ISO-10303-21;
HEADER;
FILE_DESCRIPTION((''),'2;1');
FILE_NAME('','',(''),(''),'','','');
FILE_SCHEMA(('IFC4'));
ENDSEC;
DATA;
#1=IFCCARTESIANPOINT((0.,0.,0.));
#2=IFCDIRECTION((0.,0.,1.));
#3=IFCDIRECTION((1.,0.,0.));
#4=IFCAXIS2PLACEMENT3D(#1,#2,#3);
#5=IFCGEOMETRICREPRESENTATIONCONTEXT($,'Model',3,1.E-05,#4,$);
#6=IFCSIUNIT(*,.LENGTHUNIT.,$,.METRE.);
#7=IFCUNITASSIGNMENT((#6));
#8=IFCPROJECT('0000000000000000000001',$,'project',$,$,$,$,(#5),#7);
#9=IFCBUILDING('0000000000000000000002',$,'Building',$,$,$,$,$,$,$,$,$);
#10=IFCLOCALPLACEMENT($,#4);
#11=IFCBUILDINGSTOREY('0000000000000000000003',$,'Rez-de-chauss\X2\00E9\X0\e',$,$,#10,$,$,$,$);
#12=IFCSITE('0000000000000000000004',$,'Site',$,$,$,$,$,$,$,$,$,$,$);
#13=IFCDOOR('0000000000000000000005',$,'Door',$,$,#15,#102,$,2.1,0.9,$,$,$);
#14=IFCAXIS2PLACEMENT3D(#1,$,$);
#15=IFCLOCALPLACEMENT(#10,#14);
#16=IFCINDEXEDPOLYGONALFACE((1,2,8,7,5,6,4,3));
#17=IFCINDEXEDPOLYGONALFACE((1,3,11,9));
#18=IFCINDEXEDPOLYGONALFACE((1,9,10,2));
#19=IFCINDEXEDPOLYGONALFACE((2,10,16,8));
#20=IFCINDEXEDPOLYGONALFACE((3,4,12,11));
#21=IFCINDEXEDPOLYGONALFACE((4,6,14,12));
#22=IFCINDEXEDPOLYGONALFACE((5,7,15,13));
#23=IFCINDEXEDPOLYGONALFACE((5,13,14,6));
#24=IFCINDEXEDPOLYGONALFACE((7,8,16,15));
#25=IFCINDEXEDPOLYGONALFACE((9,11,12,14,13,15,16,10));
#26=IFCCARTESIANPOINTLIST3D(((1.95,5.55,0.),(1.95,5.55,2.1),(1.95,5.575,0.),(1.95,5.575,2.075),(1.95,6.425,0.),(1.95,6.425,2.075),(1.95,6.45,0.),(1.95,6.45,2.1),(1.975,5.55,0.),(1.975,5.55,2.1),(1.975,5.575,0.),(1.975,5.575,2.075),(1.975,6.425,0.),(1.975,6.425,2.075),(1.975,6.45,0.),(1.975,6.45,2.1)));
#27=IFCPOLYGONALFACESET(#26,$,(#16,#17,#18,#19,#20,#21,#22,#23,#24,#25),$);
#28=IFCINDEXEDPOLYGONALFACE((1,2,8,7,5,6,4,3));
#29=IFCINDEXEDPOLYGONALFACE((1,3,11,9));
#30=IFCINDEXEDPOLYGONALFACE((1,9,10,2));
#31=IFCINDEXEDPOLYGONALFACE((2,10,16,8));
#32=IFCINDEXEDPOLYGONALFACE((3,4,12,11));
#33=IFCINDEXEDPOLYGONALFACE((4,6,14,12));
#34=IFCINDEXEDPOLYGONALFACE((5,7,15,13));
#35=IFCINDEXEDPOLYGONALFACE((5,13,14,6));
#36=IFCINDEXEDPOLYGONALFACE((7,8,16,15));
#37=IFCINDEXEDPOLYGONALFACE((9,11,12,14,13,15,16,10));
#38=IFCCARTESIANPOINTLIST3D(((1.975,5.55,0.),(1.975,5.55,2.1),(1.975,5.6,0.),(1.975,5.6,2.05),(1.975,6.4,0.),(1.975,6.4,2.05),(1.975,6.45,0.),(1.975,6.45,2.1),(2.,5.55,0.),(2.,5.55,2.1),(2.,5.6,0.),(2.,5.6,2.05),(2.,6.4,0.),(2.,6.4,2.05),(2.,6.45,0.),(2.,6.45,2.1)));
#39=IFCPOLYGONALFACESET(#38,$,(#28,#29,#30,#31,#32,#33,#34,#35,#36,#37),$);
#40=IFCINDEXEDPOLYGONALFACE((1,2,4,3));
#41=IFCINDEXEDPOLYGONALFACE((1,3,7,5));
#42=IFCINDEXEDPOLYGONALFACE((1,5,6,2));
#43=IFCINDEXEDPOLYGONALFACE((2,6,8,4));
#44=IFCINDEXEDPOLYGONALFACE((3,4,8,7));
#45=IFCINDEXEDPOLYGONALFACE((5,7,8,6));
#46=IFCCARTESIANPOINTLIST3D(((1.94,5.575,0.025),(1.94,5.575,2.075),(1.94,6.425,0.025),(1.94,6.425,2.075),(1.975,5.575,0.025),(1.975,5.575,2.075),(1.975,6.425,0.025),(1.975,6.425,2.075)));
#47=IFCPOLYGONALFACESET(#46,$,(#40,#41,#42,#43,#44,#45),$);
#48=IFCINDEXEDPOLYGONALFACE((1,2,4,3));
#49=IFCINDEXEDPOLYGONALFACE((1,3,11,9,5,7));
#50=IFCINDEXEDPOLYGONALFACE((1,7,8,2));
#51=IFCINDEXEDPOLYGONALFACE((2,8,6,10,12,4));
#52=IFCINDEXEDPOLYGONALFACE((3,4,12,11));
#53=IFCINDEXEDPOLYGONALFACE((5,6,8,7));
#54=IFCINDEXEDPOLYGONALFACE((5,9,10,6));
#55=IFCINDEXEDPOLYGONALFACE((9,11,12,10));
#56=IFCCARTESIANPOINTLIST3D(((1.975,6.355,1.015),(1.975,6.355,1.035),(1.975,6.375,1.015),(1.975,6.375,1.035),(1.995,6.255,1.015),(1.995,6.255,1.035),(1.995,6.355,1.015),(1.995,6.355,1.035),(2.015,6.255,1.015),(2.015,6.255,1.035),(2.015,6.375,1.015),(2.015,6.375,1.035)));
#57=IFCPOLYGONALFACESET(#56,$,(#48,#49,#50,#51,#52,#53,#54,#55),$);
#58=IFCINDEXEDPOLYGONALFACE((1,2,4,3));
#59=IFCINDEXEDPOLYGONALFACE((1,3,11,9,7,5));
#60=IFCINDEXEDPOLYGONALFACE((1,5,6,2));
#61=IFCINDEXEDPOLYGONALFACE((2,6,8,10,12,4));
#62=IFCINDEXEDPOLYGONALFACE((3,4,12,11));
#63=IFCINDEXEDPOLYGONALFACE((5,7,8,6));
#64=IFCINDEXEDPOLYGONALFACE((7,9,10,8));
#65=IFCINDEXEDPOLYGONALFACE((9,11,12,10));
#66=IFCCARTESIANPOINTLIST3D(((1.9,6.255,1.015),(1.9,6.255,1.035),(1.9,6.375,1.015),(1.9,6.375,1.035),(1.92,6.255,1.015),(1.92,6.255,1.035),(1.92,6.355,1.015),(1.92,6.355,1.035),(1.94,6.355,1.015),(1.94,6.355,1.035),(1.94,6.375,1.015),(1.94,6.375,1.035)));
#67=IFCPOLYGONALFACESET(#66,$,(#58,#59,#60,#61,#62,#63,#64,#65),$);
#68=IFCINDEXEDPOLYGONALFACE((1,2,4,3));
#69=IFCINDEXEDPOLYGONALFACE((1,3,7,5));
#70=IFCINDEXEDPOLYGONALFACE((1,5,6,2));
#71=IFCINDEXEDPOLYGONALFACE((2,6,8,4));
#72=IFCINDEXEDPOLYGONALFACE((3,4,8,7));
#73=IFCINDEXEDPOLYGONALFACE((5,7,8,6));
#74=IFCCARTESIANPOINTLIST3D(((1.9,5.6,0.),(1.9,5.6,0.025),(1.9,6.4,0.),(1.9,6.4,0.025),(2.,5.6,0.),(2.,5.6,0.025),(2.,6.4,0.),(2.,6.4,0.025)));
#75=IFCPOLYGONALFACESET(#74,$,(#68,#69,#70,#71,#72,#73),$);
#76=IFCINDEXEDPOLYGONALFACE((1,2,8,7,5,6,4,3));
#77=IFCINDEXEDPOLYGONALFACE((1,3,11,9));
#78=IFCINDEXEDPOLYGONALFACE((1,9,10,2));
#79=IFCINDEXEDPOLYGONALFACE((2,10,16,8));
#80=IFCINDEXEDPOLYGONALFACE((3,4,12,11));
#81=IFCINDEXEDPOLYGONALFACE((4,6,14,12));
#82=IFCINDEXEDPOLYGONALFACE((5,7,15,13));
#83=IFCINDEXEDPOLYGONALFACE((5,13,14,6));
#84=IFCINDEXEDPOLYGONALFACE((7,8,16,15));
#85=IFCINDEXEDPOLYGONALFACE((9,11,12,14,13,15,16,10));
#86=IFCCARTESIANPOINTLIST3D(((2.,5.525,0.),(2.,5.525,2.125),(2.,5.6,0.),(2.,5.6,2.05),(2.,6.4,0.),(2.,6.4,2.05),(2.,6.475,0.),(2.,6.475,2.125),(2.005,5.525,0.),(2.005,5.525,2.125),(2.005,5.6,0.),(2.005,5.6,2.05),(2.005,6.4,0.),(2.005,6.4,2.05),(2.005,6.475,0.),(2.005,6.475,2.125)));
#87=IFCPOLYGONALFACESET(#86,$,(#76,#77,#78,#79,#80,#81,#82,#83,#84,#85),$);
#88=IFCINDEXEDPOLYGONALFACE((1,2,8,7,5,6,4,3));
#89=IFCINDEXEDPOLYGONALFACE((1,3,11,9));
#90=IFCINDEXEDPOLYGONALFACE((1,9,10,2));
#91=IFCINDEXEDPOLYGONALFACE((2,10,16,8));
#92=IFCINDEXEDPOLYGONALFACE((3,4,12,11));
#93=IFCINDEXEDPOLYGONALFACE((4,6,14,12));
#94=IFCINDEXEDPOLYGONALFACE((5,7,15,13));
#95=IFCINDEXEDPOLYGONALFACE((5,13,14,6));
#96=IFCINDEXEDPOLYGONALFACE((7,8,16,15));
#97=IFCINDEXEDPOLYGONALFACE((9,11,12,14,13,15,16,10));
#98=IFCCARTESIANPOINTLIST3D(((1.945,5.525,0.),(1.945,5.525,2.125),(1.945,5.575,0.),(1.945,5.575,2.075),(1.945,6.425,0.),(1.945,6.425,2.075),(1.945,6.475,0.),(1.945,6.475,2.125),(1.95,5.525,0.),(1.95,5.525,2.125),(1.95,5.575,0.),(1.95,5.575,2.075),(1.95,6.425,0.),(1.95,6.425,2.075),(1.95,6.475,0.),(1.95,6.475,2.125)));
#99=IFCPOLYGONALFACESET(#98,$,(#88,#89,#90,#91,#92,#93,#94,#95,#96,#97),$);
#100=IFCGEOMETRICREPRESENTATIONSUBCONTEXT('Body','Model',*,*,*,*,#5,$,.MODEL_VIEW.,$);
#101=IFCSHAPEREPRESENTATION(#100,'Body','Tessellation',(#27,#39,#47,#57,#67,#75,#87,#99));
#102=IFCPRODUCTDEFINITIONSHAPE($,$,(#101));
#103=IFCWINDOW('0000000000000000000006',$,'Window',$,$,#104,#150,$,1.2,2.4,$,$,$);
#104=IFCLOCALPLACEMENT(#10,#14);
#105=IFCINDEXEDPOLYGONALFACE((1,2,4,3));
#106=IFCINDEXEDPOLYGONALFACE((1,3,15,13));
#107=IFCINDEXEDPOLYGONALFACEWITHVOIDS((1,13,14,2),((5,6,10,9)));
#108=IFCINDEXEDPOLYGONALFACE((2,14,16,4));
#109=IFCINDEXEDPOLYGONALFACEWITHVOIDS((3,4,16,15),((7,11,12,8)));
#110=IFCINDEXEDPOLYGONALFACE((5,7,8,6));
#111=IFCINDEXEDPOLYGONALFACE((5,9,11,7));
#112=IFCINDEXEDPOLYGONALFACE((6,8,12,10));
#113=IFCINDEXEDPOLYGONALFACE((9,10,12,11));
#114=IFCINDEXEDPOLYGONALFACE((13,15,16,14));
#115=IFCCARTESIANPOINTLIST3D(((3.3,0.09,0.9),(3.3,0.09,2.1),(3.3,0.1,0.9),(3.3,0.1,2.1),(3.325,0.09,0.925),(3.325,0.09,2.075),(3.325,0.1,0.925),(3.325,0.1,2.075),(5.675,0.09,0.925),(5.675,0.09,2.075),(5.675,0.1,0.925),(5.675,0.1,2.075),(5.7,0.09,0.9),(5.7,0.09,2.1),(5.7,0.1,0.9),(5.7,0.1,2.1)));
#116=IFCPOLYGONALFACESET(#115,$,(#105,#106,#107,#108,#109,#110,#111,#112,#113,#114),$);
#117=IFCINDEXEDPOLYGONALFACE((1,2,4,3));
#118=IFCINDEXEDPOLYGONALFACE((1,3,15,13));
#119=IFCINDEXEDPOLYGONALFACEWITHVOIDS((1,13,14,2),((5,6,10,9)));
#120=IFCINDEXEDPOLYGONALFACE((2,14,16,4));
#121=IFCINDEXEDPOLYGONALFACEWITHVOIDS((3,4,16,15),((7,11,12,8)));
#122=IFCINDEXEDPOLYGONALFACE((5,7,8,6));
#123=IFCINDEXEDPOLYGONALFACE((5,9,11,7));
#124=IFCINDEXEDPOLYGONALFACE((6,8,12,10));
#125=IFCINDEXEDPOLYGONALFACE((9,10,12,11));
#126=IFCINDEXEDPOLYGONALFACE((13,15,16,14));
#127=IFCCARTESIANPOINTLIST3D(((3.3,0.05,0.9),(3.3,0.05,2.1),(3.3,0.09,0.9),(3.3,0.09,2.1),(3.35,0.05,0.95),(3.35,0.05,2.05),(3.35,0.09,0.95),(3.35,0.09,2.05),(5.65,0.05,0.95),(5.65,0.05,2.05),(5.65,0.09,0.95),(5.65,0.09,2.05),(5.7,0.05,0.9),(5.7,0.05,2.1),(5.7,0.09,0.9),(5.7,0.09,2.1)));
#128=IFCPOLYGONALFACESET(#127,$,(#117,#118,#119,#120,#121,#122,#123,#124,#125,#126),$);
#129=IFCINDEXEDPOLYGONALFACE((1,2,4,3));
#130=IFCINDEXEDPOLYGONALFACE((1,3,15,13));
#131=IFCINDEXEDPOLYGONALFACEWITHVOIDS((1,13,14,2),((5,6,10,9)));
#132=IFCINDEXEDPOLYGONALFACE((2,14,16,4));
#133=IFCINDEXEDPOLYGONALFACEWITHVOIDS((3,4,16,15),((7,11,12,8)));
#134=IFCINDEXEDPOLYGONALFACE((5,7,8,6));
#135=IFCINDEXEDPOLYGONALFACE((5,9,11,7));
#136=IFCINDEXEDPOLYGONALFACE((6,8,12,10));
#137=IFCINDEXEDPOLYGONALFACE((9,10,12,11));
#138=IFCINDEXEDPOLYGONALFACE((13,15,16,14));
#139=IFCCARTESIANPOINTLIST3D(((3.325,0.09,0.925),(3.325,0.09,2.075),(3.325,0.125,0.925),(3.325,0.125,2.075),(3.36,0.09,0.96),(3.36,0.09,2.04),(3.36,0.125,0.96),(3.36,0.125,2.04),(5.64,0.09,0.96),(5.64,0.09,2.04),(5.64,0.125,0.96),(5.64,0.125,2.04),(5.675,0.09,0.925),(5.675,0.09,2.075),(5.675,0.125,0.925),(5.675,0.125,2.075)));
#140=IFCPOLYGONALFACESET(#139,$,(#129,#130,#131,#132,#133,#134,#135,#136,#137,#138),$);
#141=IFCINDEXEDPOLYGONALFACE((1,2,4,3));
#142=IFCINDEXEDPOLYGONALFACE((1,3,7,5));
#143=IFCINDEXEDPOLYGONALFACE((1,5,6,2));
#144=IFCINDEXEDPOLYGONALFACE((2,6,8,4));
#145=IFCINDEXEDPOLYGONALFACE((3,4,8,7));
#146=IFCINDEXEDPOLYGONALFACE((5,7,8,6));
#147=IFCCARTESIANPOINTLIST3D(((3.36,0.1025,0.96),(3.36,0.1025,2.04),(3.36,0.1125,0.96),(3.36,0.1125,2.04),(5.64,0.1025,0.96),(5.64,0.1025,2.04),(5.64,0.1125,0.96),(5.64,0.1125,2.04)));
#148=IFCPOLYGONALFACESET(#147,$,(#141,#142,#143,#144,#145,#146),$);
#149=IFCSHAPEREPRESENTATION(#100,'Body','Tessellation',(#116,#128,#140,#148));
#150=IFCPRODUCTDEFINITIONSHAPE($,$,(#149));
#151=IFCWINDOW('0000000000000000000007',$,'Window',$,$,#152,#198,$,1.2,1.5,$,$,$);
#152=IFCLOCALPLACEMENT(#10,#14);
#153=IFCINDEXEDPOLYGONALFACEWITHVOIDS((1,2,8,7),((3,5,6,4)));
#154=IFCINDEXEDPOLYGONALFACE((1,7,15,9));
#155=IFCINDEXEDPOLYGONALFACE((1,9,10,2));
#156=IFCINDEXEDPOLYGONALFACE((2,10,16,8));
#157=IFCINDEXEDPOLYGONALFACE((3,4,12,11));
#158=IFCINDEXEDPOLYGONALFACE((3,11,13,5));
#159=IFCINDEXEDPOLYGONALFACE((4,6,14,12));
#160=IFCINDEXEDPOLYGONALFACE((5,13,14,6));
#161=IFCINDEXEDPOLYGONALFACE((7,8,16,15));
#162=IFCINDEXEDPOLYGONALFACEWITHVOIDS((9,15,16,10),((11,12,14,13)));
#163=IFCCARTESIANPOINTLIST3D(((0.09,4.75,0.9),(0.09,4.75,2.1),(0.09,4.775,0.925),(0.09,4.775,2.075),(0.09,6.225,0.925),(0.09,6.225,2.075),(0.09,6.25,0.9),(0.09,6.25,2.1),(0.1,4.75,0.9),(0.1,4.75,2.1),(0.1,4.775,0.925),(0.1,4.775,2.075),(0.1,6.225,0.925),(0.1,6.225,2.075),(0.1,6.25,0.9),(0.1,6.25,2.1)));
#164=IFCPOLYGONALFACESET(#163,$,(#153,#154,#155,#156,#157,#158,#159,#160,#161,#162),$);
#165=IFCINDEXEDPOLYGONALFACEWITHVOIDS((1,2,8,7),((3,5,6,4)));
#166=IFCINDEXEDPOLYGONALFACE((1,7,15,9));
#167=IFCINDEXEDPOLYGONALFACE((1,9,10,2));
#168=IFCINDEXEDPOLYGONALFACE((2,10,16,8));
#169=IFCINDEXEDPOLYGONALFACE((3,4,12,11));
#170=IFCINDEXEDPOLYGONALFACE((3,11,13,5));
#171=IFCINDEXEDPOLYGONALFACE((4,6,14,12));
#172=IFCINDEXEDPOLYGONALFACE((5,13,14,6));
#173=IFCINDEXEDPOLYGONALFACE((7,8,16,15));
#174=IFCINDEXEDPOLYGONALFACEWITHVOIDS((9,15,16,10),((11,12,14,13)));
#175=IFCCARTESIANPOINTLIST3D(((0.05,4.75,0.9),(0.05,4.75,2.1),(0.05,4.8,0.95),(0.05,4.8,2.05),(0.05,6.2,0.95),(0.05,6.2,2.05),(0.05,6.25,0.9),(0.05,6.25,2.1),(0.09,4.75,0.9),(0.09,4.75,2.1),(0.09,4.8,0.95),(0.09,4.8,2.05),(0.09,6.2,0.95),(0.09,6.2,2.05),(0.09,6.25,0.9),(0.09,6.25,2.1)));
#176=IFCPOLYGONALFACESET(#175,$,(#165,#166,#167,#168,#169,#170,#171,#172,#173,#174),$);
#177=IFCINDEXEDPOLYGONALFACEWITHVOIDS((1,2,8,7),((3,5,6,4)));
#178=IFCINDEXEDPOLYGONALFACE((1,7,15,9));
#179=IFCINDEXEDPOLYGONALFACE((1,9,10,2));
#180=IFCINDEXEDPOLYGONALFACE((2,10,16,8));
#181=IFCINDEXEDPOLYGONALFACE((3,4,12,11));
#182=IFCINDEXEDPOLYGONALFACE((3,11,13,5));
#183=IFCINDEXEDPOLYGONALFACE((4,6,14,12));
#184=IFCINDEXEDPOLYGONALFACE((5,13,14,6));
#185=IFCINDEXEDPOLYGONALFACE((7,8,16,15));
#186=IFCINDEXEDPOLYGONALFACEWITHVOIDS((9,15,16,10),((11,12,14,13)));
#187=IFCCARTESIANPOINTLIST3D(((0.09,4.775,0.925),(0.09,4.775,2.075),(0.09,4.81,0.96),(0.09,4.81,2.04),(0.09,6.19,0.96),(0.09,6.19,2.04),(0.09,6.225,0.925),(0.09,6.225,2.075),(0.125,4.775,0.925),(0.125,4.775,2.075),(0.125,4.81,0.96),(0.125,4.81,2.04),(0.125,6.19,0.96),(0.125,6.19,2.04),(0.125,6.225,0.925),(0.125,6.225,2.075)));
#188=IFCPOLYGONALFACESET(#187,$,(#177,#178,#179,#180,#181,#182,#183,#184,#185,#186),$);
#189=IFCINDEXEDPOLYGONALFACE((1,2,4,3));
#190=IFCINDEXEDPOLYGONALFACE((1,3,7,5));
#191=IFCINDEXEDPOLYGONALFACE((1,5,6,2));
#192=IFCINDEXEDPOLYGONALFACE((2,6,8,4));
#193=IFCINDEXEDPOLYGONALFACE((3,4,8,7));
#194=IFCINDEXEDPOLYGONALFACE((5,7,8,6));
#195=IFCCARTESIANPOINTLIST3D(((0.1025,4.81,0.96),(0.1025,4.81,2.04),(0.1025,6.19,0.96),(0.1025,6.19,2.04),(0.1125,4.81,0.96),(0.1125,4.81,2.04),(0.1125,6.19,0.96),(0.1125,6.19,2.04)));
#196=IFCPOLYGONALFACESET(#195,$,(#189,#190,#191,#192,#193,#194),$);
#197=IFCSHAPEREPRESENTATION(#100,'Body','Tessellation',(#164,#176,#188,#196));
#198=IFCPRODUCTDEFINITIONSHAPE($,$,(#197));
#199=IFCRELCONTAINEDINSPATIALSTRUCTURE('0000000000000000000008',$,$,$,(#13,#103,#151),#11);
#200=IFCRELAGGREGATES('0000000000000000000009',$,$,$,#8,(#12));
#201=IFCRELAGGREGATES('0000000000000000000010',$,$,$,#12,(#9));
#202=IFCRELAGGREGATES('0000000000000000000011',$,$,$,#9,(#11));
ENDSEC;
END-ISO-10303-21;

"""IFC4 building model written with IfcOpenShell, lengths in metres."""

from ifc_helpers import new_model, si_unit, frame, origin_with_axes, place, context, subcontext, project, spatial, line, indexed_curve, outline, extrude, element, save


model = new_model("IFC4")

# Units and contexts
model_context = context("Model", 3, precision=1e-05, world=origin_with_axes())
body_context = subcontext(model_context, "Body", "Model", "MODEL_VIEW")
ifc_project = project(units=[si_unit("LENGTHUNIT", "METRE")], contexts=[model_context])

# Site, building, storey
site = spatial("IfcSite", under=ifc_project, Name="Site")
building = spatial("IfcBuilding", under=site, Name="Building")
storey_placement = place(None, origin_with_axes())
storey = spatial("IfcBuildingStorey", under=building, at=storey_placement, Name="Rez-de-chaussée")

# Door
door_1_placement = place(storey_placement, frame((2.0, 5.55, 0.0), z_axis=(0.0, 0.0, 1.0), x_axis=(0.0, 1.0, 0.0)))
element("IfcDoor", 1, at=door_1_placement, inside=storey, Name="Door", OverallHeight=2.1, OverallWidth=0.9, context=body_context, shape_type="SweptSolid", body=[
    extrude(outline(indexed_curve([(0.0, 0.0), (0.0, 2.1), (0.9, 2.1), (0.9, 0.0), (0.875, 0.0), (0.875, 2.075), (0.025, 2.075), (0.025, 0.0)], segments=[line(1, 2, 3, 4, 5, 6, 7, 8, 1)])), frame((0.0, 0.025, 0.0), z_axis=(0.0, -1.0, 0.0), x_axis=(1.0, 0.0, 0.0)), (0.0, 0.0, -1.0), 0.025),
    extrude(outline(indexed_curve([(0.0, 0.0), (0.0, 2.1), (0.9, 2.1), (0.9, 0.0), (0.85, 0.0), (0.85, 2.05), (0.05, 2.05), (0.05, 0.0)], segments=[line(1, 2, 3, 4, 5, 6, 7, 8, 1)])), frame((0.0, 0.0, 0.0), z_axis=(0.0, -1.0, 0.0), x_axis=(1.0, 0.0, 0.0)), (0.0, 0.0, -1.0), 0.025),
    extrude(outline(indexed_curve([(0.0, 0.0), (0.85, 0.0), (0.85, 0.035), (0.0, 0.035)], segments=[line(1, 2, 3, 4, 1)])), frame((0.025, 0.025, 0.025), z_axis=(0.0, 0.0, 1.0), x_axis=(1.0, 0.0, 0.0)), (0.0, 0.0, 1.0), 2.05),
    extrude(outline(indexed_curve([(0.0, 0.0), (0.0, -0.04), (-0.12, -0.04), (-0.12, -0.02), (-0.02, -0.02), (-0.02, 0.0)], segments=[line(1, 2, 3, 4, 5, 6, 1)])), frame((0.825, 0.025, 1.015), z_axis=(0.0, 0.0, 1.0), x_axis=(1.0, 0.0, 0.0)), (0.0, 0.0, 1.0), 0.02),
    extrude(outline(indexed_curve([(0.0, 0.0), (0.0, 0.04), (-0.12, 0.04), (-0.12, 0.02), (-0.02, 0.02), (-0.02, 0.0)], segments=[line(1, 2, 3, 4, 5, 6, 1)])), frame((0.825, 0.06, 1.015), z_axis=(0.0, 0.0, 1.0), x_axis=(1.0, 0.0, 0.0)), (0.0, 0.0, 1.0), 0.02),
    extrude(outline(indexed_curve([(0.0, 0.0), (0.8, 0.0), (0.8, 0.1), (0.0, 0.1)], segments=[line(1, 2, 3, 4, 1)])), frame((0.05, 0.0, 0.0), z_axis=(0.0, 0.0, 1.0), x_axis=(1.0, 0.0, 0.0)), (0.0, 0.0, 1.0), 0.025),
    extrude(outline(indexed_curve([(0.0, 0.0), (0.0, 2.125), (0.95, 2.125), (0.95, 0.0), (0.875, 0.0), (0.875, 2.05), (0.075, 2.05), (0.075, 0.0)], segments=[line(1, 2, 3, 4, 5, 6, 7, 8, 1)])), frame((-0.025, -0.005, 0.0), z_axis=(0.0, -1.0, 0.0), x_axis=(1.0, 0.0, 0.0)), (0.0, 0.0, -1.0), 0.005),
    extrude(outline(indexed_curve([(0.0, 0.0), (0.0, 2.125), (0.95, 2.125), (0.95, 0.0), (0.9, 0.0), (0.9, 2.075), (0.05, 2.075), (0.05, 0.0)], segments=[line(1, 2, 3, 4, 5, 6, 7, 8, 1)])), frame((-0.025, 0.05, 0.0), z_axis=(0.0, -1.0, 0.0), x_axis=(1.0, 0.0, 0.0)), (0.0, 0.0, -1.0), 0.005),
])

# Windows
window_1_placement = place(storey_placement, frame((3.3, 0.0, 0.9), z_axis=(0.0, 0.0, 1.0), x_axis=(1.0, 0.0, 0.0)))
element("IfcWindow", 2, at=window_1_placement, inside=storey, Name="Window", OverallHeight=1.2, OverallWidth=2.4, context=body_context, shape_type="SweptSolid", body=[
    extrude(outline(indexed_curve([(0.0, 0.0), (2.4, 0.0), (2.4, 1.2), (0.0, 1.2)], segments=[line(1, 2, 3, 4, 1)]), holes=[indexed_curve([(0.025, 0.025), (2.375, 0.025), (2.375, 1.175), (0.025, 1.175)], segments=[line(1, 2, 3, 4, 1)])]), frame((0.0, 0.09, 0.0), z_axis=(0.0, -1.0, 0.0), x_axis=(1.0, 0.0, 0.0)), (0.0, 0.0, -1.0), 0.01),
    extrude(outline(indexed_curve([(0.0, 0.0), (2.4, 0.0), (2.4, 1.2), (0.0, 1.2)], segments=[line(1, 2, 3, 4, 1)]), holes=[indexed_curve([(0.05, 0.05), (2.35, 0.05), (2.35, 1.15), (0.05, 1.15)], segments=[line(1, 2, 3, 4, 1)])]), frame((0.0, 0.05, 0.0), z_axis=(0.0, -1.0, 0.0), x_axis=(1.0, 0.0, 0.0)), (0.0, 0.0, -1.0), 0.04),
    extrude(outline(indexed_curve([(0.0, 0.0), (2.35, 0.0), (2.35, 1.15), (0.0, 1.15)], segments=[line(1, 2, 3, 4, 1)]), holes=[indexed_curve([(0.035, 0.035), (2.315, 0.035), (2.315, 1.115), (0.035, 1.115)], segments=[line(1, 2, 3, 4, 1)])]), frame((0.025, 0.09, 0.025), z_axis=(0.0, -1.0, 0.0), x_axis=(1.0, 0.0, 0.0)), (0.0, 0.0, -1.0), 0.035),
    extrude(outline(indexed_curve([(0.035, 0.035), (2.315, 0.035), (2.315, 1.115), (0.035, 1.115)], segments=[line(1, 2, 3, 4, 1)])), frame((0.025, 0.1025, 0.025), z_axis=(0.0, -1.0, 0.0), x_axis=(1.0, 0.0, 0.0)), (0.0, 0.0, -1.0), 0.01),
])
window_2_placement = place(storey_placement, frame((0.0, 6.25, 0.9), z_axis=(0.0, 0.0, 1.0), x_axis=(0.0, -1.0, 0.0)))
element("IfcWindow", 3, at=window_2_placement, inside=storey, Name="Window", OverallHeight=1.2, OverallWidth=1.5, context=body_context, shape_type="SweptSolid", body=[
    extrude(outline(indexed_curve([(0.0, 0.0), (1.5, 0.0), (1.5, 1.2), (0.0, 1.2)], segments=[line(1, 2, 3, 4, 1)]), holes=[indexed_curve([(0.025, 0.025), (1.475, 0.025), (1.475, 1.175), (0.025, 1.175)], segments=[line(1, 2, 3, 4, 1)])]), frame((0.0, 0.09, 0.0), z_axis=(0.0, -1.0, 0.0), x_axis=(1.0, 0.0, 0.0)), (0.0, 0.0, -1.0), 0.01),
    extrude(outline(indexed_curve([(0.0, 0.0), (1.5, 0.0), (1.5, 1.2), (0.0, 1.2)], segments=[line(1, 2, 3, 4, 1)]), holes=[indexed_curve([(0.05, 0.05), (1.45, 0.05), (1.45, 1.15), (0.05, 1.15)], segments=[line(1, 2, 3, 4, 1)])]), frame((0.0, 0.05, 0.0), z_axis=(0.0, -1.0, 0.0), x_axis=(1.0, 0.0, 0.0)), (0.0, 0.0, -1.0), 0.04),
    extrude(outline(indexed_curve([(0.0, 0.0), (1.45, 0.0), (1.45, 1.15), (0.0, 1.15)], segments=[line(1, 2, 3, 4, 1)]), holes=[indexed_curve([(0.035, 0.035), (1.415, 0.035), (1.415, 1.115), (0.035, 1.115)], segments=[line(1, 2, 3, 4, 1)])]), frame((0.025, 0.09, 0.025), z_axis=(0.0, -1.0, 0.0), x_axis=(1.0, 0.0, 0.0)), (0.0, 0.0, -1.0), 0.035),
    extrude(outline(indexed_curve([(0.035, 0.035), (1.415, 0.035), (1.415, 1.115), (0.035, 1.115)], segments=[line(1, 2, 3, 4, 1)])), frame((0.025, 0.1025, 0.025), z_axis=(0.0, -1.0, 0.0), x_axis=(1.0, 0.0, 0.0)), (0.0, 0.0, -1.0), 0.01),
])

save(model, "model.ifc")
